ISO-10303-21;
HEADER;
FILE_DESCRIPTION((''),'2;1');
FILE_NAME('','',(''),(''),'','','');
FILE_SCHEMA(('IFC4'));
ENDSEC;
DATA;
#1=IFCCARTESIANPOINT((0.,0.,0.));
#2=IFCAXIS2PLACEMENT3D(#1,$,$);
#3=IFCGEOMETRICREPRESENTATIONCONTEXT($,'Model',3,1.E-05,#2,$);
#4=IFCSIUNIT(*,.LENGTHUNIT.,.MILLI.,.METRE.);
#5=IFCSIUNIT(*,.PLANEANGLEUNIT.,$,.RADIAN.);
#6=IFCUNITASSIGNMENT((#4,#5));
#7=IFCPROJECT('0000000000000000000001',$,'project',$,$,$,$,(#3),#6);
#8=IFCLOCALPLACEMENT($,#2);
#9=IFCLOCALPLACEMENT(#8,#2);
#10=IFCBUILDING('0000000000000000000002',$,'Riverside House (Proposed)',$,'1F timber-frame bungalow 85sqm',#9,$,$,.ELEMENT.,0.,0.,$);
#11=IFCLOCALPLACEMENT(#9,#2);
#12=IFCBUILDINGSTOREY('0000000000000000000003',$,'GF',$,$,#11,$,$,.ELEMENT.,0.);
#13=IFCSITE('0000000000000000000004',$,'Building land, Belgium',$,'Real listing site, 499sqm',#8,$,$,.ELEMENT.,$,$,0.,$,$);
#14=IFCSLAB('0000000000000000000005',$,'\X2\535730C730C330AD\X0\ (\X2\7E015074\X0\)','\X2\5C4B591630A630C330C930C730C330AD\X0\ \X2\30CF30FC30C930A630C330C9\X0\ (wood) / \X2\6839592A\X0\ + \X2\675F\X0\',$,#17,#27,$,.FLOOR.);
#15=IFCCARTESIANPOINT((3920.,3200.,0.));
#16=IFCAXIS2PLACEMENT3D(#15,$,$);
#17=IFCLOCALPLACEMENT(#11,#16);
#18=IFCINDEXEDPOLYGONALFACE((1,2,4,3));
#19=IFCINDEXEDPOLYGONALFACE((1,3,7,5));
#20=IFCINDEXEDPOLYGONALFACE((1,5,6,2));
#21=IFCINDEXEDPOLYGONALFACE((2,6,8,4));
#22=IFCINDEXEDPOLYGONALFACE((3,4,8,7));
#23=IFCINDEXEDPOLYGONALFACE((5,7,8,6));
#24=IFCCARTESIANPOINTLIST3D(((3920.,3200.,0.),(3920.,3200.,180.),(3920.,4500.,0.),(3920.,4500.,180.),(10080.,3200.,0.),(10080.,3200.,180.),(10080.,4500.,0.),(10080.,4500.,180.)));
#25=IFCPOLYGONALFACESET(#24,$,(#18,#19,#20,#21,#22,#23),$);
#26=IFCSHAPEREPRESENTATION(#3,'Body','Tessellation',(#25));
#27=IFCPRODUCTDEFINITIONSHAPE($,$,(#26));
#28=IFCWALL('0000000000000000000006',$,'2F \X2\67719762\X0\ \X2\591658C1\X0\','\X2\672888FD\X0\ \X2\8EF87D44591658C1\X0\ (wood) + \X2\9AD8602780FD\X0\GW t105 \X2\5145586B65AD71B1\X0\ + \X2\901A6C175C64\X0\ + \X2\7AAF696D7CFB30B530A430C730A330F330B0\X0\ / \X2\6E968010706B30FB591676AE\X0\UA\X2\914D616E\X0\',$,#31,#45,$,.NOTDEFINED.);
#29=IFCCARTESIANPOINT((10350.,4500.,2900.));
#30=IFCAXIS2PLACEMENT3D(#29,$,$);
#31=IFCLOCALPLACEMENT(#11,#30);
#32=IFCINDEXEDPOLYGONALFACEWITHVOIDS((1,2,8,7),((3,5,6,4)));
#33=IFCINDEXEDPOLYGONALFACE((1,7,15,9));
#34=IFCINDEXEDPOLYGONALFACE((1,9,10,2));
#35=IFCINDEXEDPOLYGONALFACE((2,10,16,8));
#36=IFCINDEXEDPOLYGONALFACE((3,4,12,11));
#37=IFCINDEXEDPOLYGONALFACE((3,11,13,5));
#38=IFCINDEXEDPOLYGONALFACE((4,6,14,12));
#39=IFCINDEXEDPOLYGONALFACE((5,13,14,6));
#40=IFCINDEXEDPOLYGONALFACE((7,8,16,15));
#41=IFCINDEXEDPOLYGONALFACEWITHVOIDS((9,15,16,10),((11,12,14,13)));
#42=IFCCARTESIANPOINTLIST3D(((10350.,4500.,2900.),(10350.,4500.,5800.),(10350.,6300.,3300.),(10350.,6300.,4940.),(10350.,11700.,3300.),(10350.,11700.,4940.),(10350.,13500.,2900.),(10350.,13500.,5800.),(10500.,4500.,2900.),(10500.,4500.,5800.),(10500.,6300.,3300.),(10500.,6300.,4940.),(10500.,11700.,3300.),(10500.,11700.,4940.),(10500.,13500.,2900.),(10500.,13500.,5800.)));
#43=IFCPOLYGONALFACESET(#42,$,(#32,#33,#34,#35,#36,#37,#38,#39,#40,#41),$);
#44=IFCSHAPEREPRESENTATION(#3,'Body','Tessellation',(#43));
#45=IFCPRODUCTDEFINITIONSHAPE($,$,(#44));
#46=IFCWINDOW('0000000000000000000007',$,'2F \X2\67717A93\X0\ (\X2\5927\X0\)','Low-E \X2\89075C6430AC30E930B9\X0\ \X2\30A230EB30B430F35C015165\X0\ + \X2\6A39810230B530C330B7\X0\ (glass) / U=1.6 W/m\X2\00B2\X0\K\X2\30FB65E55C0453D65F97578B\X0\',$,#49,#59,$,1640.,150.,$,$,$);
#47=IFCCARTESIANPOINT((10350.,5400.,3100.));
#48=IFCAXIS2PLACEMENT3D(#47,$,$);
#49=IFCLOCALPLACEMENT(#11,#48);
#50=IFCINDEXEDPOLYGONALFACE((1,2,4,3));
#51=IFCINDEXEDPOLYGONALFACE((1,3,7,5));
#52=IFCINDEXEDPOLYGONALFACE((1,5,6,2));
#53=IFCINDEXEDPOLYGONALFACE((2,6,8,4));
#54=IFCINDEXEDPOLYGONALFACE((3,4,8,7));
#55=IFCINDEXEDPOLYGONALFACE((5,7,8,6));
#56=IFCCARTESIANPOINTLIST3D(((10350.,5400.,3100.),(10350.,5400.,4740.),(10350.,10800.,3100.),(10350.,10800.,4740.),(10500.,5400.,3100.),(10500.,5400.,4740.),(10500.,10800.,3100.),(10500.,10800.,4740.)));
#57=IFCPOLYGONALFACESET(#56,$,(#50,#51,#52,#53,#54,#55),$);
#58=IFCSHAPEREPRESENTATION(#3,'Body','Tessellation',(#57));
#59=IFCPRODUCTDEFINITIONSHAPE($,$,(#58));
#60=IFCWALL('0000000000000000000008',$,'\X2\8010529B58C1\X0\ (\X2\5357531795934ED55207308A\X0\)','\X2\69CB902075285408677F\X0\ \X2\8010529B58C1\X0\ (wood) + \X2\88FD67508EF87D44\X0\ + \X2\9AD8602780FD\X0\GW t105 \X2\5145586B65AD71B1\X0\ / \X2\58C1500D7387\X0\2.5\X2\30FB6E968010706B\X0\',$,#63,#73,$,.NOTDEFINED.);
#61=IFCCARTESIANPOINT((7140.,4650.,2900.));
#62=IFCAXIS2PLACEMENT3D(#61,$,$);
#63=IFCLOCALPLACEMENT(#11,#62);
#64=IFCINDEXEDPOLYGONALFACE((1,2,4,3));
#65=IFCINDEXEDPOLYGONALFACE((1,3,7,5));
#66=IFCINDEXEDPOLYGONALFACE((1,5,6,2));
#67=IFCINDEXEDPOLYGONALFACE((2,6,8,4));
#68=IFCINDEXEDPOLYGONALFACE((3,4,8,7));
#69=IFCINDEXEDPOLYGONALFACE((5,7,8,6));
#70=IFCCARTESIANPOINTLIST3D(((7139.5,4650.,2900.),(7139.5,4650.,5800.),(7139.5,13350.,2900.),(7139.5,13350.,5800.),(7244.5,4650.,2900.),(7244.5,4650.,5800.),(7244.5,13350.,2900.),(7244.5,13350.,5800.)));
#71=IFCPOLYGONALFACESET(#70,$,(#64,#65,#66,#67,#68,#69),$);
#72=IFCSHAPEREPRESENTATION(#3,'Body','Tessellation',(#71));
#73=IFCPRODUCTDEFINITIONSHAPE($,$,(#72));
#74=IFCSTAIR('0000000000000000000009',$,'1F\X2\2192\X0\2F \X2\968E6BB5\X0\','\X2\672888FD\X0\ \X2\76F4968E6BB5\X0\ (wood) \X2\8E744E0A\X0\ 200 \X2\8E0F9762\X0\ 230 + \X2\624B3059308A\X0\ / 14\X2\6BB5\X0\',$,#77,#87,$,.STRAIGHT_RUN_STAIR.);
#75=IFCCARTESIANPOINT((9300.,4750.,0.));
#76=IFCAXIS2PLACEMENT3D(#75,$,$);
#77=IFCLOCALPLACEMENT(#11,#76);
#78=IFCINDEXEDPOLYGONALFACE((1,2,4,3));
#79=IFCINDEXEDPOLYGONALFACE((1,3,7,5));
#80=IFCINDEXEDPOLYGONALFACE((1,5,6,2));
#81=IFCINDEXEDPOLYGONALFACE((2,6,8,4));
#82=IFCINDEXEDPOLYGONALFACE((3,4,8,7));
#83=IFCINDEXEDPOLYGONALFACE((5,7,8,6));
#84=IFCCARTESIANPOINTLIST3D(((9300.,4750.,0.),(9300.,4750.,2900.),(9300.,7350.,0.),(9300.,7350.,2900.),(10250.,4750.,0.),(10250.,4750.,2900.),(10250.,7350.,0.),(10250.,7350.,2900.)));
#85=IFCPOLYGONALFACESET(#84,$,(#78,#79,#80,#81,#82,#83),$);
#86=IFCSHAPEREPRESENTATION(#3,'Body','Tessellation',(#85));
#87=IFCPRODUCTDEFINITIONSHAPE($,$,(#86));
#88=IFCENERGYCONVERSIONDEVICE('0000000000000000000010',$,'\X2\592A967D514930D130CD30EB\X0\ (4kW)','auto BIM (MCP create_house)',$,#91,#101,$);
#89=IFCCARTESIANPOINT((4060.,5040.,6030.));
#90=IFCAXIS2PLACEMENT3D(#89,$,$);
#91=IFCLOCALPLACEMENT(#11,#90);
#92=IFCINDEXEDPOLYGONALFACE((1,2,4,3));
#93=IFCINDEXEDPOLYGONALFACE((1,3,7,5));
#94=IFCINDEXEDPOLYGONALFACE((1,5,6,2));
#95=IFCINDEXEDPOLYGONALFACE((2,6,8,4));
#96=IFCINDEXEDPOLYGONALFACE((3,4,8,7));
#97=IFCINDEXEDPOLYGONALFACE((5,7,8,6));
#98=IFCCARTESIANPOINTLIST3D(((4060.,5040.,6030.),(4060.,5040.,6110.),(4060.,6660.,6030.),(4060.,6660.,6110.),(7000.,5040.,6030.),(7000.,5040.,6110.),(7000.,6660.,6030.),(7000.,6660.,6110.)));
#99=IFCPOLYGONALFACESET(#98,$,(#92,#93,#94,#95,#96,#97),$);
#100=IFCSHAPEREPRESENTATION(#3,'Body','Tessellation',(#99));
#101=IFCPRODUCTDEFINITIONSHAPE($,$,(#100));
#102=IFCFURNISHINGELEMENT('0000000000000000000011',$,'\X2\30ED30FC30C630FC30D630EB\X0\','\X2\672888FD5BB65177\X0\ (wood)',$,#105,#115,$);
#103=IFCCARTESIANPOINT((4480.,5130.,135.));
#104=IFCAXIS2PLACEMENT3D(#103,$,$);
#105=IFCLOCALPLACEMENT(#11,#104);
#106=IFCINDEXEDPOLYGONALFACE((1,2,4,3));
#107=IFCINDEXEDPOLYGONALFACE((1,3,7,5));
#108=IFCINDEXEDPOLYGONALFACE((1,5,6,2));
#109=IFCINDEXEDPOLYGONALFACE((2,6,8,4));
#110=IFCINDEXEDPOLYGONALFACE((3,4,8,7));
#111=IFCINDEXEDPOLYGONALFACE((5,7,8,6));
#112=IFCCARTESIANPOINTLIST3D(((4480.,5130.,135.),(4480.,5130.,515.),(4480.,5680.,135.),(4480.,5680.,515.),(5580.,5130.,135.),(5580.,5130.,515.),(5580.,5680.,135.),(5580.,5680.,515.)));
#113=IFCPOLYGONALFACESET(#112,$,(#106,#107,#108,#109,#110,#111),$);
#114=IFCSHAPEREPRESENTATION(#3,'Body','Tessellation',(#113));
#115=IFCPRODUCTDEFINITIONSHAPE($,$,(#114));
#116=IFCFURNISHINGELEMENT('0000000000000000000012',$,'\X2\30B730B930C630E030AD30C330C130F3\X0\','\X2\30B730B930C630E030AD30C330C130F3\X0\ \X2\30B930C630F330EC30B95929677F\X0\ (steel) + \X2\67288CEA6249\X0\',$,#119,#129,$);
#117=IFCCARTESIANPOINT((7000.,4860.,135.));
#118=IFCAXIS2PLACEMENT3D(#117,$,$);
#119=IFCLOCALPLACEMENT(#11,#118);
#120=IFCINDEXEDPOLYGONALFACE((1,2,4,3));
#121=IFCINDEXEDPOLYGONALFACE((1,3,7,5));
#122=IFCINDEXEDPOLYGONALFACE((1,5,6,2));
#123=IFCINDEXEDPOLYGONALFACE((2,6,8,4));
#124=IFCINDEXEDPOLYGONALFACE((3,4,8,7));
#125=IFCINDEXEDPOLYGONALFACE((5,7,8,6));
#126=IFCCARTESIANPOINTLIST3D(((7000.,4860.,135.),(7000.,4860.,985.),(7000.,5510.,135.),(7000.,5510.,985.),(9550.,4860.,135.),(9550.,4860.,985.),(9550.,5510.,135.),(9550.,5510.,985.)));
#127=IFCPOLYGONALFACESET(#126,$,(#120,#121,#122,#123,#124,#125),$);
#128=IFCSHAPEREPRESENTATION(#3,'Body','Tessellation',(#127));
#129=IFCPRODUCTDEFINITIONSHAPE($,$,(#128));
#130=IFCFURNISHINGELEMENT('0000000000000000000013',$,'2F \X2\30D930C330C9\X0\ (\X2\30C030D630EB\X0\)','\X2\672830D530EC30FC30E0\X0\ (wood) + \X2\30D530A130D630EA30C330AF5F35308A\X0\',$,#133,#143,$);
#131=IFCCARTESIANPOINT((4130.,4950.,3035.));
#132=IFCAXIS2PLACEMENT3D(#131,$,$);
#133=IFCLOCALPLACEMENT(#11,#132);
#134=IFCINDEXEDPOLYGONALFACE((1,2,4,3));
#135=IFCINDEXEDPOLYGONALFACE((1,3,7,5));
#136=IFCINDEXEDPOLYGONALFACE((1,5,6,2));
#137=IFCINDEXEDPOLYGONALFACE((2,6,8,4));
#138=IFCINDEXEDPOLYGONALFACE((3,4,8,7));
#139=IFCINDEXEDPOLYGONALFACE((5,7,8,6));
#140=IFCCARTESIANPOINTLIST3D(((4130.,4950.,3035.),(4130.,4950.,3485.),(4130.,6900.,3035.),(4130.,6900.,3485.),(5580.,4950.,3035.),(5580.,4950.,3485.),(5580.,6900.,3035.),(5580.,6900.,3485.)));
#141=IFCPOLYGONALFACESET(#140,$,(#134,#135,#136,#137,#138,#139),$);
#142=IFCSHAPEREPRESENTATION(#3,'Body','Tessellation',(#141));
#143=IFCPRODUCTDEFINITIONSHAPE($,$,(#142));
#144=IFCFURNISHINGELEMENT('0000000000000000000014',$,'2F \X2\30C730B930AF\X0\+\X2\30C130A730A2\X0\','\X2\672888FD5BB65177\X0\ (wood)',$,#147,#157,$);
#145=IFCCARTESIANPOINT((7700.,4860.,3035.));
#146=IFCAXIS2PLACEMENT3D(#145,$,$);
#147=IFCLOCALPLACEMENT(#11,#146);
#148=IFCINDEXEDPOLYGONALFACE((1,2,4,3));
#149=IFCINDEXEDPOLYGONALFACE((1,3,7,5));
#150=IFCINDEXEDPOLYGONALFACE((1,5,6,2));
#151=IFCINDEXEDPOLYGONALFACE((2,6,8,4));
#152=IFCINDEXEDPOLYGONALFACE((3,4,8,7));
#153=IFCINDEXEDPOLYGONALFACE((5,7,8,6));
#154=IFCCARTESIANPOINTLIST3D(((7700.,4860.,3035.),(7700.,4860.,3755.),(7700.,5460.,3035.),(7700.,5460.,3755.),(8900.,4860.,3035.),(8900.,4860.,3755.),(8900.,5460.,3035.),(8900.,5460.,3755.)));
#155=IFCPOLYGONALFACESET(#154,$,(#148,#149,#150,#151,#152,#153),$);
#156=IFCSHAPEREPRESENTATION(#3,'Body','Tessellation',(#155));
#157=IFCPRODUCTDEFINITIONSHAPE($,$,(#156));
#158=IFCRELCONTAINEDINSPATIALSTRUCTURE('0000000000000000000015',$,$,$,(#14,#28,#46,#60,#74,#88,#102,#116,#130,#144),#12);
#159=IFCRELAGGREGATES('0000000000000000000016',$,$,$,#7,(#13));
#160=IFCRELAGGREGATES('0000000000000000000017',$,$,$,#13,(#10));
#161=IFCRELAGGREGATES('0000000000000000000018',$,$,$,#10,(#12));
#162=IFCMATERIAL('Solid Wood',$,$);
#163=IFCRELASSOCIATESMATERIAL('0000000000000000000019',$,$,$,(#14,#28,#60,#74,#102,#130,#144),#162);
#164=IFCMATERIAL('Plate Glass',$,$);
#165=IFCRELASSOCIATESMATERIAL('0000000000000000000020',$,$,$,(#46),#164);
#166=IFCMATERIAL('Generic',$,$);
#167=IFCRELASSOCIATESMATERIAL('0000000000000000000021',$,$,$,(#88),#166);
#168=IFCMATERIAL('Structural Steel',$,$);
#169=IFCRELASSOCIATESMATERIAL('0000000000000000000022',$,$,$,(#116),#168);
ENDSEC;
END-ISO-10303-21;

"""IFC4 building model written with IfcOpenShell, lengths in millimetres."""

from ifc_helpers import new_model, si_unit, frame, frame_2d, origin, place, context, project, spatial, rectangle, extrude, material, element, fill, save


model = new_model("IFC4")

# Units and contexts
model_context = context("Model", 3, precision=1e-05, world=origin())
ifc_project = project(units=[si_unit("LENGTHUNIT", "METRE", prefix="MILLI"), si_unit("PLANEANGLEUNIT", "RADIAN")], contexts=[model_context])

# Site, building, storey
site_placement = place(None, origin())
site = spatial("IfcSite", under=ifc_project, at=site_placement, Name="Building land, Belgium", ObjectType="Real listing site, 499sqm", CompositionType="ELEMENT", RefElevation=0.0)
building_placement = place(site_placement, origin())
building = spatial("IfcBuilding", under=site, at=building_placement, Name="Riverside House (Proposed)", ObjectType="1F timber-frame bungalow 85sqm", CompositionType="ELEMENT", ElevationOfRefHeight=0.0, ElevationOfTerrain=0.0)
storey_placement = place(building_placement, origin())
storey = spatial("IfcBuildingStorey", under=building, at=storey_placement, Name="GF", CompositionType="ELEMENT", Elevation=0.0)

# Slab
ifc_material_1 = material(Name="Solid Wood")
slab_placement = place(storey_placement, frame((3920.0, 3200.0, 0.0)))
element("IfcSlab", 1, at=slab_placement, inside=storey, material=ifc_material_1, Name="南デッキ (縁側)", Description="屋外ウッドデッキ ハードウッド (wood) / 根太 + 束", PredefinedType="FLOOR", context=model_context, shape_type="SweptSolid", body=[
    extrude(rectangle(XDim=6160.0, YDim=1300.0, at=frame_2d((3080.0, 650.0))), frame((3920.0, 3200.0, 0.0)), (0.0, 0.0, 1.0), 180.0),
])

# Shared definitions
ifc_material_2 = material(Name="Plate Glass")

# Wall, opening, window
wall_1_placement = place(storey_placement, frame((10350.0, 4500.0, 2900.0)))
wall_1 = element("IfcWall", 2, at=wall_1_placement, inside=storey, material=ifc_material_1, Name="2F 東面 外壁", Description="木製 軸組外壁 (wood) + 高性能GW t105 充填断熱 + 通気層 + 窯業系サイディング / 準耐火・外皮UA配慮", PredefinedType="NOTDEFINED", context=model_context, shape_type="SweptSolid", body=[
    extrude(rectangle(XDim=150.0, YDim=9000.0, at=frame_2d((75.0, 4500.0))), frame((10350.0, 4500.0, 2900.0)), (0.0, 0.0, 1.0), 2900.0),
])
opening_1_placement = place(storey_placement, frame((10350.0, 5400.0, 3100.0)))
opening_1 = element("IfcOpeningElement", 3, at=opening_1_placement, cuts=wall_1, PredefinedType="NOTDEFINED", context=model_context, shape_type="SweptSolid", body=[
    extrude(rectangle(XDim=150.0, YDim=5400.0, at=frame_2d((75.0, 2700.0))), frame((10350.0, 5400.0, 3100.0)), (0.0, 0.0, 1.0), 1640.0),
])
window_1_placement = place(storey_placement, frame((10350.0, 5400.0, 3100.0)))
window_1 = element("IfcWindow", 4, at=window_1_placement, inside=storey, material=ifc_material_2, Name="2F 東窓 (大)", Description="Low-E 複層ガラス アルゴン封入 + 樹脂サッシ (glass) / U=1.6 W/m²K・日射取得型", OverallHeight=1640.0, OverallWidth=150.0, context=model_context, shape_type="SweptSolid", body=[
    extrude(rectangle(XDim=150.0, YDim=5400.0, at=frame_2d((75.0, 2700.0))), frame((10350.0, 5400.0, 3100.0)), (0.0, 0.0, 1.0), 1640.0),
])
fill(opening_1, window_1)

# Wall
wall_2_placement = place(storey_placement, frame((7140.0, 4650.0, 2900.0)))
element("IfcWall", 5, at=wall_2_placement, inside=storey, material=ifc_material_1, Name="耐力壁 (南北間仕切り)", Description="構造用合板 耐力壁 (wood) + 製材軸組 + 高性能GW t105 充填断熱 / 壁倍率2.5・準耐火", PredefinedType="NOTDEFINED", context=model_context, shape_type="SweptSolid", body=[
    extrude(rectangle(XDim=105.0, YDim=8700.0, at=frame_2d((52.0, 4350.0))), frame((7140.0, 4650.0, 2900.0)), (0.0, 0.0, 1.0), 2900.0),
])

# Stair
stair_placement = place(storey_placement, frame((9300.0, 4750.0, 0.0)))
element("IfcStair", 6, at=stair_placement, inside=storey, material=ifc_material_1, Name="1F→2F 階段", Description="木製 直階段 (wood) 蹴上 200 踏面 230 + 手すり / 14段", PredefinedType="STRAIGHT_RUN_STAIR", context=model_context, shape_type="SweptSolid", body=[
    extrude(rectangle(XDim=950.0, YDim=2600.0, at=frame_2d((475.0, 1300.0))), frame((9300.0, 4750.0, 0.0)), (0.0, 0.0, 1.0), 2900.0),
])

# Energy conversion device
ifc_material_3 = material(Name="Generic")
energy_conversion_device_placement = place(storey_placement, frame((4060.0, 5040.0, 6030.0)))
element("IfcEnergyConversionDevice", 7, at=energy_conversion_device_placement, inside=storey, material=ifc_material_3, Name="太陽光パネル (4kW)", Description="auto BIM (MCP create_house)", context=model_context, shape_type="SweptSolid", body=[
    extrude(rectangle(XDim=2940.0, YDim=1620.0, at=frame_2d((1470.0, 810.0))), frame((4060.0, 5040.0, 6030.0)), (0.0, 0.0, 1.0), 80.0),
])

# Furnishing elements
furnishing_1_placement = place(storey_placement, frame((4480.0, 5130.0, 135.0)))
element("IfcFurnishingElement", 8, at=furnishing_1_placement, inside=storey, material=ifc_material_1, Name="ローテーブル", Description="木製家具 (wood)", context=model_context, shape_type="SweptSolid", body=[
    extrude(rectangle(XDim=1100.0, YDim=550.0, at=frame_2d((550.0, 275.0))), frame((4480.0, 5130.0, 135.0)), (0.0, 0.0, 1.0), 380.0),
])
ifc_material_4 = material(Name="Structural Steel")
furnishing_2_placement = place(storey_placement, frame((7000.0, 4860.0, 135.0)))
element("IfcFurnishingElement", 9, at=furnishing_2_placement, inside=storey, material=ifc_material_4, Name="システムキッチン", Description="システムキッチン ステンレス天板 (steel) + 木質扉", context=model_context, shape_type="SweptSolid", body=[
    extrude(rectangle(XDim=2550.0, YDim=650.0, at=frame_2d((1275.0, 325.0))), frame((7000.0, 4860.0, 135.0)), (0.0, 0.0, 1.0), 850.0),
])
furnishing_3_placement = place(storey_placement, frame((4130.0, 4950.0, 3035.0)))
element("IfcFurnishingElement", 10, at=furnishing_3_placement, inside=storey, material=ifc_material_1, Name="2F ベッド (ダブル)", Description="木フレーム (wood) + ファブリック張り", context=model_context, shape_type="SweptSolid", body=[
    extrude(rectangle(XDim=1450.0, YDim=1950.0, at=frame_2d((725.0, 975.0))), frame((4130.0, 4950.0, 3035.0)), (0.0, 0.0, 1.0), 450.0),
])
furnishing_4_placement = place(storey_placement, frame((7700.0, 4860.0, 3035.0)))
element("IfcFurnishingElement", 11, at=furnishing_4_placement, inside=storey, material=ifc_material_1, Name="2F デスク+チェア", Description="木製家具 (wood)", context=model_context, shape_type="SweptSolid", body=[
    extrude(rectangle(XDim=1200.0, YDim=600.0, at=frame_2d((600.0, 300.0))), frame((7700.0, 4860.0, 3035.0)), (0.0, 0.0, 1.0), 720.0),
])

save(model, "model.ifc")
